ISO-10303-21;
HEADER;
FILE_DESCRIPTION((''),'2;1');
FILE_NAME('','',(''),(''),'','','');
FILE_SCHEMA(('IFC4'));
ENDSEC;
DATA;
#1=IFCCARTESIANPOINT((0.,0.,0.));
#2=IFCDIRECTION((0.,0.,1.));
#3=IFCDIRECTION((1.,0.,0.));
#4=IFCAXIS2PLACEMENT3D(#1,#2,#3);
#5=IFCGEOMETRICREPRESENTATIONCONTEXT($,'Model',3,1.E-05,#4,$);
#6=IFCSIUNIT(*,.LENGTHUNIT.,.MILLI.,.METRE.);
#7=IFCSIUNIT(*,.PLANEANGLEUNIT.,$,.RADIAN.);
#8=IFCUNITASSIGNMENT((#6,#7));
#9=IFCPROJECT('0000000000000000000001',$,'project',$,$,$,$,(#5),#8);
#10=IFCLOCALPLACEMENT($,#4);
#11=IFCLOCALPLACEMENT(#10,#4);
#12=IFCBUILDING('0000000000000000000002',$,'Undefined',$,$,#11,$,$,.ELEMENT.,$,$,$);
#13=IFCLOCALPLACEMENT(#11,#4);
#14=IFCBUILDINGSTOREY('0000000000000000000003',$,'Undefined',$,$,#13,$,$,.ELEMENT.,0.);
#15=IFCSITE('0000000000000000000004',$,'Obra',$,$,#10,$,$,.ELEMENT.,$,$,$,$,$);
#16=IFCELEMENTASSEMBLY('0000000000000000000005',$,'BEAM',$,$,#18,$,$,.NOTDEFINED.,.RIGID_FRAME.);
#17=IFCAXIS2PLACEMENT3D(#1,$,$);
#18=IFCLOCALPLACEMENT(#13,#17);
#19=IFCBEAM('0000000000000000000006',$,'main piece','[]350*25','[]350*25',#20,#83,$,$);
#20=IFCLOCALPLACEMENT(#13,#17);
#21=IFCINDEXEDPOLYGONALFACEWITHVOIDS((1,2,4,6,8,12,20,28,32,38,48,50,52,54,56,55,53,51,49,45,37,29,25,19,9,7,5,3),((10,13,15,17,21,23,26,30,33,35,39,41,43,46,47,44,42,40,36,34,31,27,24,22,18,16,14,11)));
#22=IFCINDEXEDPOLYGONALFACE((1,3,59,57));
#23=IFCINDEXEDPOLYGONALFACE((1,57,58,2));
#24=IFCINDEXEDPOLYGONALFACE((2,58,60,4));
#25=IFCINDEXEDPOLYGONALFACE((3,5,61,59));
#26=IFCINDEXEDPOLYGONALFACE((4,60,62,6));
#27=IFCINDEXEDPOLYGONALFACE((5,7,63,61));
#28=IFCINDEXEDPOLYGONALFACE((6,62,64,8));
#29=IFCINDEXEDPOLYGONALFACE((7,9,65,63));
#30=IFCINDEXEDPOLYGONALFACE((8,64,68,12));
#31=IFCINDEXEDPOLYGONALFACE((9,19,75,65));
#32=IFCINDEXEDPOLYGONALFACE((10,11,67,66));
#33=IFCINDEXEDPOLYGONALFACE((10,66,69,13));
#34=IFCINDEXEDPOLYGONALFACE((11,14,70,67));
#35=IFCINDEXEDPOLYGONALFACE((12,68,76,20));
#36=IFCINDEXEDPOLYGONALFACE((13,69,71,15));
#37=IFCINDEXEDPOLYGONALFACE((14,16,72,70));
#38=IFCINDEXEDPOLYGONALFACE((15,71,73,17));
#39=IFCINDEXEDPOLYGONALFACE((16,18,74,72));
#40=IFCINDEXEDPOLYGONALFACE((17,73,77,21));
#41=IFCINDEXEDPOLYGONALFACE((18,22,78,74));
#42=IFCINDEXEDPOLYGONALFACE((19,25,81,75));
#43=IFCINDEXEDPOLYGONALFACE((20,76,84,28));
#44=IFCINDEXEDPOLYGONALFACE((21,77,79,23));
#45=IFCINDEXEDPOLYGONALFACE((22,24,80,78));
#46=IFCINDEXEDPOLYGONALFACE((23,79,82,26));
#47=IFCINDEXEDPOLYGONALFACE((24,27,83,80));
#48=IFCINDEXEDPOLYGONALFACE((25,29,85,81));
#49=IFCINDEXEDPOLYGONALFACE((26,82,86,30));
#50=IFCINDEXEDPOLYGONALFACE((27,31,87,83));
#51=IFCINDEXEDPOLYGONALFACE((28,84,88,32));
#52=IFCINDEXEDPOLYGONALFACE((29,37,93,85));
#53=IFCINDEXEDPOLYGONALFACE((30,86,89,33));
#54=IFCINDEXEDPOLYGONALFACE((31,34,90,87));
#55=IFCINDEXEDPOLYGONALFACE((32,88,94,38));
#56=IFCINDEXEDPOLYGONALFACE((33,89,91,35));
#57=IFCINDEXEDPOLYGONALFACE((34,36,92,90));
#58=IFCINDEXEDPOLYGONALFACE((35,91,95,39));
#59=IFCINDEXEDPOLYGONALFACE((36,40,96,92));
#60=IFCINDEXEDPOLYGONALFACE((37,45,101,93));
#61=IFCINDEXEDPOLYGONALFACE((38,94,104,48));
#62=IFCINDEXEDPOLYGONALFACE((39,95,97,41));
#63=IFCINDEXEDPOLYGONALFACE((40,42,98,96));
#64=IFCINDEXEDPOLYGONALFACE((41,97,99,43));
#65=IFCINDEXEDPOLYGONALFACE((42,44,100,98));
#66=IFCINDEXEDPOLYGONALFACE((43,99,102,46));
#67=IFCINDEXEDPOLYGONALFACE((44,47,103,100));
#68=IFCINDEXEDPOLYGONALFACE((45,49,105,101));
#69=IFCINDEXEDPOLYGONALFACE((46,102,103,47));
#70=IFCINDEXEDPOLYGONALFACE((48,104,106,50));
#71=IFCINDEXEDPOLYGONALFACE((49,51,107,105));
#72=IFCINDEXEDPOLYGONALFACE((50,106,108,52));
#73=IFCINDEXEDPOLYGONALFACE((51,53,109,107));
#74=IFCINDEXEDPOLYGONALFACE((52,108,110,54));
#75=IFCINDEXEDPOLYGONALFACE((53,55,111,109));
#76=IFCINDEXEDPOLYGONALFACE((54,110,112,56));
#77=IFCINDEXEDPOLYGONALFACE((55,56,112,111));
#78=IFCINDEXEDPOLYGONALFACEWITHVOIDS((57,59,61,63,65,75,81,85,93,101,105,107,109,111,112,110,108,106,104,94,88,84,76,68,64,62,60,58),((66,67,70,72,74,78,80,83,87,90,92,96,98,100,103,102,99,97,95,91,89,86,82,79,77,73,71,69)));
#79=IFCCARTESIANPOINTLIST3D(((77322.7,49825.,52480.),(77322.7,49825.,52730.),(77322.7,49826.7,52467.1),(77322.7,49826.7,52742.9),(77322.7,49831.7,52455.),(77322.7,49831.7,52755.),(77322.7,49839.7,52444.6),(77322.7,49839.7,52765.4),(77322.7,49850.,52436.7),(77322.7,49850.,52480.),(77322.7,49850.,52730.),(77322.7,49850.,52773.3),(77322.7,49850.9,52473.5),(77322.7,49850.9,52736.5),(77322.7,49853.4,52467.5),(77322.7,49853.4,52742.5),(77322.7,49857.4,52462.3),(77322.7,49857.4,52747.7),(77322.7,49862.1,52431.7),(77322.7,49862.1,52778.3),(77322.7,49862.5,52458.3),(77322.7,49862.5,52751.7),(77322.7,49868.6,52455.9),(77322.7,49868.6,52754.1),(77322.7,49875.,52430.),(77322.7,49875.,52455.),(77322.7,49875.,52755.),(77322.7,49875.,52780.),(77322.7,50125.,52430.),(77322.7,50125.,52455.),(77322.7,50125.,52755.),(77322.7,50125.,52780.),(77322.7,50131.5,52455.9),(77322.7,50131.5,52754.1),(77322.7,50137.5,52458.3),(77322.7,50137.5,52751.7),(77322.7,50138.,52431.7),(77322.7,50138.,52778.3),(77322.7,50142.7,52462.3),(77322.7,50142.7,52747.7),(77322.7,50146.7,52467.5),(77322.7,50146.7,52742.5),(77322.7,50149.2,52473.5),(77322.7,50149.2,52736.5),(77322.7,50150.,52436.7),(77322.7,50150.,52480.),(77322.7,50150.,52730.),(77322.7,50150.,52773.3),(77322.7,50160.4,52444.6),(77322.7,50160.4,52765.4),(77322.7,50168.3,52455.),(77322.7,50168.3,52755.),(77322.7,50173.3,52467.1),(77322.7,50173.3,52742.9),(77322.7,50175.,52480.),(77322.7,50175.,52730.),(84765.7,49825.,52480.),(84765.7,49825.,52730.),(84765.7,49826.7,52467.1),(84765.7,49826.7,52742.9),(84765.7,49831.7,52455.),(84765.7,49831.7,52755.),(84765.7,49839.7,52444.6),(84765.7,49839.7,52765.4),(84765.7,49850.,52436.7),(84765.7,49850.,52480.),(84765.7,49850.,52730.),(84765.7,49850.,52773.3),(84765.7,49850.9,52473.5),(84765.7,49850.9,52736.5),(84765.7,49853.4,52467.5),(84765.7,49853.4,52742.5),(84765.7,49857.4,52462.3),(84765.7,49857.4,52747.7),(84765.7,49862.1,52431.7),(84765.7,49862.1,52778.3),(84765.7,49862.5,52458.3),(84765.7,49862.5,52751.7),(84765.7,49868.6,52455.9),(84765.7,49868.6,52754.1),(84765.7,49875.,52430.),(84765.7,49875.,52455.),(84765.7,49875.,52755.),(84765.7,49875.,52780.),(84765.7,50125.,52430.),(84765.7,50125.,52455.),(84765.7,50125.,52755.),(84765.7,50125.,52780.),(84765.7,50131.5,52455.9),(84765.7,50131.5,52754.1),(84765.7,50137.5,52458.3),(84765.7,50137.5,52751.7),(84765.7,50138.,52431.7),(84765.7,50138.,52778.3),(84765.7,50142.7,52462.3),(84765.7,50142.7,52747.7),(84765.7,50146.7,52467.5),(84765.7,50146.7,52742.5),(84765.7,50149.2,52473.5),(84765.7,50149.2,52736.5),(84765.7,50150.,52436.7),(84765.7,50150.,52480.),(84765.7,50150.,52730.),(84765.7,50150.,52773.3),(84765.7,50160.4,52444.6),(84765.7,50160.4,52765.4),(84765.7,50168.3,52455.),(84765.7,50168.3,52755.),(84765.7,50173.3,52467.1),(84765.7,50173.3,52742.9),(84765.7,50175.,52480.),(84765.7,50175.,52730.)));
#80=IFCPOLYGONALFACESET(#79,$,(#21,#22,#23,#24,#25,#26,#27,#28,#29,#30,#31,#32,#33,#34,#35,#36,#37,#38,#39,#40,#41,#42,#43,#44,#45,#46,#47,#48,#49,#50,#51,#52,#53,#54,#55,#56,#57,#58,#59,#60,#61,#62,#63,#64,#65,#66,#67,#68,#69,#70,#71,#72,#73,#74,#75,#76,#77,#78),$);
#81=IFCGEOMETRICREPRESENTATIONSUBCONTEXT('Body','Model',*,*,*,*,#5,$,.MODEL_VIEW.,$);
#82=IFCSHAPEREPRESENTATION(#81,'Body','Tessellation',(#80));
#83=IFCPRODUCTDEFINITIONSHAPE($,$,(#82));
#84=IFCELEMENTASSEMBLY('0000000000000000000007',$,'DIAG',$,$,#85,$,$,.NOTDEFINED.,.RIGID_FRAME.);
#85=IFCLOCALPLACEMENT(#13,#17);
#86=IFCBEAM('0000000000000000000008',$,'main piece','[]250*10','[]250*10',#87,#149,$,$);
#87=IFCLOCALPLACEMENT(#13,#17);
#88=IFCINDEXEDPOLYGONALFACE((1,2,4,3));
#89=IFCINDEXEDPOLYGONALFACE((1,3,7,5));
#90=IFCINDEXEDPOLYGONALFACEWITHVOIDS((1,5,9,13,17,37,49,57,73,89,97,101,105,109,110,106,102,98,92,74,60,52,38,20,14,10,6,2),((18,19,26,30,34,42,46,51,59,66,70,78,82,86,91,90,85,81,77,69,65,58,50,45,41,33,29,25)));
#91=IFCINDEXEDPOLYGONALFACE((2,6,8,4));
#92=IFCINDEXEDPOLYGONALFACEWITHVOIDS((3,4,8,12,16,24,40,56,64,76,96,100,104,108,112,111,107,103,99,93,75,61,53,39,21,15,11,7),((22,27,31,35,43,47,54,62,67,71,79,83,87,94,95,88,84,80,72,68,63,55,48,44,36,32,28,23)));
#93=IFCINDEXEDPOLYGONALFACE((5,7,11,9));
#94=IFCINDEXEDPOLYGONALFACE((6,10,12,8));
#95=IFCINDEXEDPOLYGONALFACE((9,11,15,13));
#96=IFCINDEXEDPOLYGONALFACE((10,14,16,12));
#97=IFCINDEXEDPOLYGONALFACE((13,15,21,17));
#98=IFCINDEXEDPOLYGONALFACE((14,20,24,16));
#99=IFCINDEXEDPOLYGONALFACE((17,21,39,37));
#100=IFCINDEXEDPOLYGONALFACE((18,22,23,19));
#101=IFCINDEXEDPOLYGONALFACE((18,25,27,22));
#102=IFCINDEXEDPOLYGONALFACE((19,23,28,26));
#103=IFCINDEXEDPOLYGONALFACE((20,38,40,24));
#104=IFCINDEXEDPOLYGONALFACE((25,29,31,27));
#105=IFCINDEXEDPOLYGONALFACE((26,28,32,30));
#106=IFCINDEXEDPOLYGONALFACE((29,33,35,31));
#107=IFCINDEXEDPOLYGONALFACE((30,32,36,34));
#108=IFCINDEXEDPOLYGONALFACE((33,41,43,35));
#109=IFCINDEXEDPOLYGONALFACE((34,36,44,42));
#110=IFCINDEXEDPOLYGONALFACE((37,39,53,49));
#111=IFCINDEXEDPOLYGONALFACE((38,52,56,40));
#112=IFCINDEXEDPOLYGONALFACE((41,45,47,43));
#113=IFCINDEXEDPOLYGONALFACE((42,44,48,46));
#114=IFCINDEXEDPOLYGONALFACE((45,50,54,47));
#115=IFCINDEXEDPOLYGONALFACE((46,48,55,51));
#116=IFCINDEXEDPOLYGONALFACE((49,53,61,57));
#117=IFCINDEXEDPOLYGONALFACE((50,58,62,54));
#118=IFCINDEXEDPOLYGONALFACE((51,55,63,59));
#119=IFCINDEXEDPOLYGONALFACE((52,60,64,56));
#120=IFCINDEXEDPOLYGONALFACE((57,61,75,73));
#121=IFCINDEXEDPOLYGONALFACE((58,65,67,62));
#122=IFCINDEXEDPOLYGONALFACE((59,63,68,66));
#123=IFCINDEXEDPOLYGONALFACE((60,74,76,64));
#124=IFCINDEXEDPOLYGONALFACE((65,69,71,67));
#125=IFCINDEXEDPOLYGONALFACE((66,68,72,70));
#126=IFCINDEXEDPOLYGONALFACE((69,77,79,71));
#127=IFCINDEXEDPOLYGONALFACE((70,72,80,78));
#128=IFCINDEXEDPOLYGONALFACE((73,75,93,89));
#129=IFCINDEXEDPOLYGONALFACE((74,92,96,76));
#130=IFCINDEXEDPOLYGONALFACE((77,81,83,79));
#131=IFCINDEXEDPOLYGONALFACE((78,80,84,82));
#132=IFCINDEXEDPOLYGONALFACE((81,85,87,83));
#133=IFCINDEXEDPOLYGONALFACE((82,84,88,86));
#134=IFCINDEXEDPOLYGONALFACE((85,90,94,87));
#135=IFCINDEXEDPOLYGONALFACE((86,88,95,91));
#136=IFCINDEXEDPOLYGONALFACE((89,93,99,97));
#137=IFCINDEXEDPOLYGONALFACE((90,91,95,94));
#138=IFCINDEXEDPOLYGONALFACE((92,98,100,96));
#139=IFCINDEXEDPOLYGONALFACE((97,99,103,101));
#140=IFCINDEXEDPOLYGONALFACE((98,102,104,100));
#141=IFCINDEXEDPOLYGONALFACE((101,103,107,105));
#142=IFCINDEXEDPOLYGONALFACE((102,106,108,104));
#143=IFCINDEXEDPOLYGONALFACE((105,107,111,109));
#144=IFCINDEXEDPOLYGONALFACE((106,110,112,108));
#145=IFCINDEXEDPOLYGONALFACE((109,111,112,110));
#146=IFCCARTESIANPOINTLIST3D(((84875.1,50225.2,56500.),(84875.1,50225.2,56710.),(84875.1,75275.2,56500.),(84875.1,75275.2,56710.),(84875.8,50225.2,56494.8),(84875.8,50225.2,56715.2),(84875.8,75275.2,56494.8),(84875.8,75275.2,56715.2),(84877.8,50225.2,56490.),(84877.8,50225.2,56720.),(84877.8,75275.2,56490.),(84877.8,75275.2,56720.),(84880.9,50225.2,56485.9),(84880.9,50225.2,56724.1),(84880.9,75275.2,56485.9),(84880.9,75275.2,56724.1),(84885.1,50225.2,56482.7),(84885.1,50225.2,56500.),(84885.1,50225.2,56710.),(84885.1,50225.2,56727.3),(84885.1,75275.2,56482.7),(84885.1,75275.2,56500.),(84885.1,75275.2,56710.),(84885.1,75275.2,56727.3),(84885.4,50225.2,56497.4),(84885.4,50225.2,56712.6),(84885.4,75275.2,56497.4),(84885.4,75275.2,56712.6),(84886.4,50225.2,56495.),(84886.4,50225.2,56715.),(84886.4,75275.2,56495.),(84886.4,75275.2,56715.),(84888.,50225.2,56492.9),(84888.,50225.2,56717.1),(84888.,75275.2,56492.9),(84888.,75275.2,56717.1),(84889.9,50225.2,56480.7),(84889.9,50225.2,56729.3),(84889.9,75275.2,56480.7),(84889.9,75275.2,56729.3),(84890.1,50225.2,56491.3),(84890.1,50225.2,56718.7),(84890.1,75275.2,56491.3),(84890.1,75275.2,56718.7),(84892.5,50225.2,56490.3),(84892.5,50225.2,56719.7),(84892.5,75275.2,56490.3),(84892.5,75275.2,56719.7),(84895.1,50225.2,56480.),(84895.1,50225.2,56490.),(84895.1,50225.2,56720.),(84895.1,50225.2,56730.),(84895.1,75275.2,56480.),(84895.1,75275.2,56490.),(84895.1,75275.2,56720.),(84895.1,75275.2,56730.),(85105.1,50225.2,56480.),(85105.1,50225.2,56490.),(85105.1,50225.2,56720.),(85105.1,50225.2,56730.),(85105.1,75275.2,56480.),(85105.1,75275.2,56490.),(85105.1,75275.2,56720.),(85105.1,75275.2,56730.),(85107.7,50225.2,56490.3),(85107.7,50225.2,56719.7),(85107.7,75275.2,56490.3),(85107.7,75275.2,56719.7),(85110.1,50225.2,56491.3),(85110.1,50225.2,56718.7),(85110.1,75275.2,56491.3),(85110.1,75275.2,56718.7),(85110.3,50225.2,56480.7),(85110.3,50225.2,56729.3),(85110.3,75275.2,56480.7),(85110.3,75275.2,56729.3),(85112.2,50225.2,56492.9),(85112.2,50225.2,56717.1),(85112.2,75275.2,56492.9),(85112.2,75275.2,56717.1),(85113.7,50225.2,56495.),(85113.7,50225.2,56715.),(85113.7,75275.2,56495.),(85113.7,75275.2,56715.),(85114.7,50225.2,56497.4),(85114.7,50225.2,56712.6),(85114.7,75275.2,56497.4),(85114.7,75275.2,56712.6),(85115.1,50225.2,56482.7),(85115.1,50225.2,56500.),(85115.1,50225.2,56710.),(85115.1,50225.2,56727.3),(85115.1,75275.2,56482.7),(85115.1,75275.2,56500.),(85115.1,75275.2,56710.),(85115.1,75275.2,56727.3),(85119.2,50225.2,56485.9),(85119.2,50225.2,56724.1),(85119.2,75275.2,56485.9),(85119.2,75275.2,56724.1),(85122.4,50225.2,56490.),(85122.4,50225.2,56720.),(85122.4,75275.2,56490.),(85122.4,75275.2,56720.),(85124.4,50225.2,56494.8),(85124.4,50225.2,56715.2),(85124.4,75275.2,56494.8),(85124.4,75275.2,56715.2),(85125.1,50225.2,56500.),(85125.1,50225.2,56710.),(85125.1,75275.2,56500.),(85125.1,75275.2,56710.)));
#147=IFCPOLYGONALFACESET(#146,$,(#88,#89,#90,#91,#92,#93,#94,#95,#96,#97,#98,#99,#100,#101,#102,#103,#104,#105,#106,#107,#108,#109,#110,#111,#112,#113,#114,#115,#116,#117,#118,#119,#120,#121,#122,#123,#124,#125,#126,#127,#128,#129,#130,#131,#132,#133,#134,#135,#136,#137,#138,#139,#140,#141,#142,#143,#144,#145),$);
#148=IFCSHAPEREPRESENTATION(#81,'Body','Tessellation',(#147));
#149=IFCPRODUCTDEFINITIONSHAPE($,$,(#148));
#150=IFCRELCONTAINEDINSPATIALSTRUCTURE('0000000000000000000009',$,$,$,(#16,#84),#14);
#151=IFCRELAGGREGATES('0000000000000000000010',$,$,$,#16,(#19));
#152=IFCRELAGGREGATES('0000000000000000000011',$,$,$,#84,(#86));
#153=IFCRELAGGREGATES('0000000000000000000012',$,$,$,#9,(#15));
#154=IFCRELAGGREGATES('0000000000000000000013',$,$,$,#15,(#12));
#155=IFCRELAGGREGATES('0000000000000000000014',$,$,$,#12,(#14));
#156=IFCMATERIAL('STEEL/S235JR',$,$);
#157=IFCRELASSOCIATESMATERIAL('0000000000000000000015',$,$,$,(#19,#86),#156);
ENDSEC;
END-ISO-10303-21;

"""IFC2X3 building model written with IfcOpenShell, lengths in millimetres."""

from ifc_helpers import new_model, si_unit, frame, origin_with_axes, origin_2d_with_axis, place, context, subcontext, project, spatial, hollow_rectangle, extrude, material, element, aggregate, save


model = new_model("IFC2X3")

# Units and contexts
model_context = context("Model", 3, precision=1e-05, world=origin_with_axes())
body_context = subcontext(model_context, "Body", "Model", "MODEL_VIEW")
ifc_project = project(units=[si_unit("LENGTHUNIT", "METRE", prefix="MILLI"), si_unit("PLANEANGLEUNIT", "RADIAN")], contexts=[model_context])

# Site, building, storey
site_placement = place(None, origin_with_axes())
site = spatial("IfcSite", under=ifc_project, at=site_placement, Name="Obra", CompositionType="ELEMENT")
building_placement = place(site_placement, origin_with_axes())
building = spatial("IfcBuilding", under=site, at=building_placement, Name="Undefined", CompositionType="ELEMENT")
storey_placement = place(building_placement, origin_with_axes())
storey = spatial("IfcBuildingStorey", under=building, at=storey_placement, Name="Undefined", CompositionType="ELEMENT", Elevation=0.0)

# Shared definitions
ifc_material = material(Name="STEEL/S235JR")

# Element assembly, beam
assembly_1_placement = place(storey_placement, origin_with_axes())
assembly_1 = element("IfcElementAssembly", 1, at=assembly_1_placement, inside=storey, Name="BEAM", AssemblyPlace="NOTDEFINED", PredefinedType="RIGID_FRAME")
beam_1_placement = place(assembly_1_placement, frame((84765.7, 50000.0, 52605.0), z_axis=(0.0, 0.0, 1.0), x_axis=(-1.0, 0.0, 0.0)))
beam_1 = element("IfcBeam", 2, at=beam_1_placement, material=ifc_material, Name="main piece", Description="[]350*25", ObjectType="[]350*25", context=body_context, shape_type="SweptSolid", body=[
    extrude(hollow_rectangle(XDim=350.0, YDim=350.0, WallThickness=25.0, InnerFilletRadius=25.0, OuterFilletRadius=50.0, at=origin_2d_with_axis()), frame((7443.0, 0.0, 0.0), z_axis=(-1.0, 0.0, 0.0), x_axis=(0.0, -1.0, 0.0)), (0.0, 0.0, 1.0), 7443.0),
])
aggregate(assembly_1, [beam_1])

# Element assembly, beam
assembly_2_placement = place(storey_placement, origin_with_axes())
assembly_2 = element("IfcElementAssembly", 3, at=assembly_2_placement, inside=storey, Name="DIAG", AssemblyPlace="NOTDEFINED", PredefinedType="RIGID_FRAME")
beam_2_placement = place(assembly_2_placement, frame((85000.1, 50225.2, 56605.0), z_axis=(0.0, 0.0, 1.0), x_axis=(0.0, 1.0, 0.0)))
beam_2 = element("IfcBeam", 4, at=beam_2_placement, material=ifc_material, Name="main piece", Description="[]250*10", ObjectType="[]250*10", context=body_context, shape_type="SweptSolid", body=[
    extrude(hollow_rectangle(XDim=250.0, YDim=250.0, WallThickness=10.0, InnerFilletRadius=10.0, OuterFilletRadius=20.0, at=origin_2d_with_axis()), frame((25050.0, 0.0, 0.0), z_axis=(-1.0, 0.0, 0.0), x_axis=(0.0, -1.0, 0.0)), (0.0, 0.0, 1.0), 25050.0),
])
aggregate(assembly_2, [beam_2])

save(model, "model.ifc")
